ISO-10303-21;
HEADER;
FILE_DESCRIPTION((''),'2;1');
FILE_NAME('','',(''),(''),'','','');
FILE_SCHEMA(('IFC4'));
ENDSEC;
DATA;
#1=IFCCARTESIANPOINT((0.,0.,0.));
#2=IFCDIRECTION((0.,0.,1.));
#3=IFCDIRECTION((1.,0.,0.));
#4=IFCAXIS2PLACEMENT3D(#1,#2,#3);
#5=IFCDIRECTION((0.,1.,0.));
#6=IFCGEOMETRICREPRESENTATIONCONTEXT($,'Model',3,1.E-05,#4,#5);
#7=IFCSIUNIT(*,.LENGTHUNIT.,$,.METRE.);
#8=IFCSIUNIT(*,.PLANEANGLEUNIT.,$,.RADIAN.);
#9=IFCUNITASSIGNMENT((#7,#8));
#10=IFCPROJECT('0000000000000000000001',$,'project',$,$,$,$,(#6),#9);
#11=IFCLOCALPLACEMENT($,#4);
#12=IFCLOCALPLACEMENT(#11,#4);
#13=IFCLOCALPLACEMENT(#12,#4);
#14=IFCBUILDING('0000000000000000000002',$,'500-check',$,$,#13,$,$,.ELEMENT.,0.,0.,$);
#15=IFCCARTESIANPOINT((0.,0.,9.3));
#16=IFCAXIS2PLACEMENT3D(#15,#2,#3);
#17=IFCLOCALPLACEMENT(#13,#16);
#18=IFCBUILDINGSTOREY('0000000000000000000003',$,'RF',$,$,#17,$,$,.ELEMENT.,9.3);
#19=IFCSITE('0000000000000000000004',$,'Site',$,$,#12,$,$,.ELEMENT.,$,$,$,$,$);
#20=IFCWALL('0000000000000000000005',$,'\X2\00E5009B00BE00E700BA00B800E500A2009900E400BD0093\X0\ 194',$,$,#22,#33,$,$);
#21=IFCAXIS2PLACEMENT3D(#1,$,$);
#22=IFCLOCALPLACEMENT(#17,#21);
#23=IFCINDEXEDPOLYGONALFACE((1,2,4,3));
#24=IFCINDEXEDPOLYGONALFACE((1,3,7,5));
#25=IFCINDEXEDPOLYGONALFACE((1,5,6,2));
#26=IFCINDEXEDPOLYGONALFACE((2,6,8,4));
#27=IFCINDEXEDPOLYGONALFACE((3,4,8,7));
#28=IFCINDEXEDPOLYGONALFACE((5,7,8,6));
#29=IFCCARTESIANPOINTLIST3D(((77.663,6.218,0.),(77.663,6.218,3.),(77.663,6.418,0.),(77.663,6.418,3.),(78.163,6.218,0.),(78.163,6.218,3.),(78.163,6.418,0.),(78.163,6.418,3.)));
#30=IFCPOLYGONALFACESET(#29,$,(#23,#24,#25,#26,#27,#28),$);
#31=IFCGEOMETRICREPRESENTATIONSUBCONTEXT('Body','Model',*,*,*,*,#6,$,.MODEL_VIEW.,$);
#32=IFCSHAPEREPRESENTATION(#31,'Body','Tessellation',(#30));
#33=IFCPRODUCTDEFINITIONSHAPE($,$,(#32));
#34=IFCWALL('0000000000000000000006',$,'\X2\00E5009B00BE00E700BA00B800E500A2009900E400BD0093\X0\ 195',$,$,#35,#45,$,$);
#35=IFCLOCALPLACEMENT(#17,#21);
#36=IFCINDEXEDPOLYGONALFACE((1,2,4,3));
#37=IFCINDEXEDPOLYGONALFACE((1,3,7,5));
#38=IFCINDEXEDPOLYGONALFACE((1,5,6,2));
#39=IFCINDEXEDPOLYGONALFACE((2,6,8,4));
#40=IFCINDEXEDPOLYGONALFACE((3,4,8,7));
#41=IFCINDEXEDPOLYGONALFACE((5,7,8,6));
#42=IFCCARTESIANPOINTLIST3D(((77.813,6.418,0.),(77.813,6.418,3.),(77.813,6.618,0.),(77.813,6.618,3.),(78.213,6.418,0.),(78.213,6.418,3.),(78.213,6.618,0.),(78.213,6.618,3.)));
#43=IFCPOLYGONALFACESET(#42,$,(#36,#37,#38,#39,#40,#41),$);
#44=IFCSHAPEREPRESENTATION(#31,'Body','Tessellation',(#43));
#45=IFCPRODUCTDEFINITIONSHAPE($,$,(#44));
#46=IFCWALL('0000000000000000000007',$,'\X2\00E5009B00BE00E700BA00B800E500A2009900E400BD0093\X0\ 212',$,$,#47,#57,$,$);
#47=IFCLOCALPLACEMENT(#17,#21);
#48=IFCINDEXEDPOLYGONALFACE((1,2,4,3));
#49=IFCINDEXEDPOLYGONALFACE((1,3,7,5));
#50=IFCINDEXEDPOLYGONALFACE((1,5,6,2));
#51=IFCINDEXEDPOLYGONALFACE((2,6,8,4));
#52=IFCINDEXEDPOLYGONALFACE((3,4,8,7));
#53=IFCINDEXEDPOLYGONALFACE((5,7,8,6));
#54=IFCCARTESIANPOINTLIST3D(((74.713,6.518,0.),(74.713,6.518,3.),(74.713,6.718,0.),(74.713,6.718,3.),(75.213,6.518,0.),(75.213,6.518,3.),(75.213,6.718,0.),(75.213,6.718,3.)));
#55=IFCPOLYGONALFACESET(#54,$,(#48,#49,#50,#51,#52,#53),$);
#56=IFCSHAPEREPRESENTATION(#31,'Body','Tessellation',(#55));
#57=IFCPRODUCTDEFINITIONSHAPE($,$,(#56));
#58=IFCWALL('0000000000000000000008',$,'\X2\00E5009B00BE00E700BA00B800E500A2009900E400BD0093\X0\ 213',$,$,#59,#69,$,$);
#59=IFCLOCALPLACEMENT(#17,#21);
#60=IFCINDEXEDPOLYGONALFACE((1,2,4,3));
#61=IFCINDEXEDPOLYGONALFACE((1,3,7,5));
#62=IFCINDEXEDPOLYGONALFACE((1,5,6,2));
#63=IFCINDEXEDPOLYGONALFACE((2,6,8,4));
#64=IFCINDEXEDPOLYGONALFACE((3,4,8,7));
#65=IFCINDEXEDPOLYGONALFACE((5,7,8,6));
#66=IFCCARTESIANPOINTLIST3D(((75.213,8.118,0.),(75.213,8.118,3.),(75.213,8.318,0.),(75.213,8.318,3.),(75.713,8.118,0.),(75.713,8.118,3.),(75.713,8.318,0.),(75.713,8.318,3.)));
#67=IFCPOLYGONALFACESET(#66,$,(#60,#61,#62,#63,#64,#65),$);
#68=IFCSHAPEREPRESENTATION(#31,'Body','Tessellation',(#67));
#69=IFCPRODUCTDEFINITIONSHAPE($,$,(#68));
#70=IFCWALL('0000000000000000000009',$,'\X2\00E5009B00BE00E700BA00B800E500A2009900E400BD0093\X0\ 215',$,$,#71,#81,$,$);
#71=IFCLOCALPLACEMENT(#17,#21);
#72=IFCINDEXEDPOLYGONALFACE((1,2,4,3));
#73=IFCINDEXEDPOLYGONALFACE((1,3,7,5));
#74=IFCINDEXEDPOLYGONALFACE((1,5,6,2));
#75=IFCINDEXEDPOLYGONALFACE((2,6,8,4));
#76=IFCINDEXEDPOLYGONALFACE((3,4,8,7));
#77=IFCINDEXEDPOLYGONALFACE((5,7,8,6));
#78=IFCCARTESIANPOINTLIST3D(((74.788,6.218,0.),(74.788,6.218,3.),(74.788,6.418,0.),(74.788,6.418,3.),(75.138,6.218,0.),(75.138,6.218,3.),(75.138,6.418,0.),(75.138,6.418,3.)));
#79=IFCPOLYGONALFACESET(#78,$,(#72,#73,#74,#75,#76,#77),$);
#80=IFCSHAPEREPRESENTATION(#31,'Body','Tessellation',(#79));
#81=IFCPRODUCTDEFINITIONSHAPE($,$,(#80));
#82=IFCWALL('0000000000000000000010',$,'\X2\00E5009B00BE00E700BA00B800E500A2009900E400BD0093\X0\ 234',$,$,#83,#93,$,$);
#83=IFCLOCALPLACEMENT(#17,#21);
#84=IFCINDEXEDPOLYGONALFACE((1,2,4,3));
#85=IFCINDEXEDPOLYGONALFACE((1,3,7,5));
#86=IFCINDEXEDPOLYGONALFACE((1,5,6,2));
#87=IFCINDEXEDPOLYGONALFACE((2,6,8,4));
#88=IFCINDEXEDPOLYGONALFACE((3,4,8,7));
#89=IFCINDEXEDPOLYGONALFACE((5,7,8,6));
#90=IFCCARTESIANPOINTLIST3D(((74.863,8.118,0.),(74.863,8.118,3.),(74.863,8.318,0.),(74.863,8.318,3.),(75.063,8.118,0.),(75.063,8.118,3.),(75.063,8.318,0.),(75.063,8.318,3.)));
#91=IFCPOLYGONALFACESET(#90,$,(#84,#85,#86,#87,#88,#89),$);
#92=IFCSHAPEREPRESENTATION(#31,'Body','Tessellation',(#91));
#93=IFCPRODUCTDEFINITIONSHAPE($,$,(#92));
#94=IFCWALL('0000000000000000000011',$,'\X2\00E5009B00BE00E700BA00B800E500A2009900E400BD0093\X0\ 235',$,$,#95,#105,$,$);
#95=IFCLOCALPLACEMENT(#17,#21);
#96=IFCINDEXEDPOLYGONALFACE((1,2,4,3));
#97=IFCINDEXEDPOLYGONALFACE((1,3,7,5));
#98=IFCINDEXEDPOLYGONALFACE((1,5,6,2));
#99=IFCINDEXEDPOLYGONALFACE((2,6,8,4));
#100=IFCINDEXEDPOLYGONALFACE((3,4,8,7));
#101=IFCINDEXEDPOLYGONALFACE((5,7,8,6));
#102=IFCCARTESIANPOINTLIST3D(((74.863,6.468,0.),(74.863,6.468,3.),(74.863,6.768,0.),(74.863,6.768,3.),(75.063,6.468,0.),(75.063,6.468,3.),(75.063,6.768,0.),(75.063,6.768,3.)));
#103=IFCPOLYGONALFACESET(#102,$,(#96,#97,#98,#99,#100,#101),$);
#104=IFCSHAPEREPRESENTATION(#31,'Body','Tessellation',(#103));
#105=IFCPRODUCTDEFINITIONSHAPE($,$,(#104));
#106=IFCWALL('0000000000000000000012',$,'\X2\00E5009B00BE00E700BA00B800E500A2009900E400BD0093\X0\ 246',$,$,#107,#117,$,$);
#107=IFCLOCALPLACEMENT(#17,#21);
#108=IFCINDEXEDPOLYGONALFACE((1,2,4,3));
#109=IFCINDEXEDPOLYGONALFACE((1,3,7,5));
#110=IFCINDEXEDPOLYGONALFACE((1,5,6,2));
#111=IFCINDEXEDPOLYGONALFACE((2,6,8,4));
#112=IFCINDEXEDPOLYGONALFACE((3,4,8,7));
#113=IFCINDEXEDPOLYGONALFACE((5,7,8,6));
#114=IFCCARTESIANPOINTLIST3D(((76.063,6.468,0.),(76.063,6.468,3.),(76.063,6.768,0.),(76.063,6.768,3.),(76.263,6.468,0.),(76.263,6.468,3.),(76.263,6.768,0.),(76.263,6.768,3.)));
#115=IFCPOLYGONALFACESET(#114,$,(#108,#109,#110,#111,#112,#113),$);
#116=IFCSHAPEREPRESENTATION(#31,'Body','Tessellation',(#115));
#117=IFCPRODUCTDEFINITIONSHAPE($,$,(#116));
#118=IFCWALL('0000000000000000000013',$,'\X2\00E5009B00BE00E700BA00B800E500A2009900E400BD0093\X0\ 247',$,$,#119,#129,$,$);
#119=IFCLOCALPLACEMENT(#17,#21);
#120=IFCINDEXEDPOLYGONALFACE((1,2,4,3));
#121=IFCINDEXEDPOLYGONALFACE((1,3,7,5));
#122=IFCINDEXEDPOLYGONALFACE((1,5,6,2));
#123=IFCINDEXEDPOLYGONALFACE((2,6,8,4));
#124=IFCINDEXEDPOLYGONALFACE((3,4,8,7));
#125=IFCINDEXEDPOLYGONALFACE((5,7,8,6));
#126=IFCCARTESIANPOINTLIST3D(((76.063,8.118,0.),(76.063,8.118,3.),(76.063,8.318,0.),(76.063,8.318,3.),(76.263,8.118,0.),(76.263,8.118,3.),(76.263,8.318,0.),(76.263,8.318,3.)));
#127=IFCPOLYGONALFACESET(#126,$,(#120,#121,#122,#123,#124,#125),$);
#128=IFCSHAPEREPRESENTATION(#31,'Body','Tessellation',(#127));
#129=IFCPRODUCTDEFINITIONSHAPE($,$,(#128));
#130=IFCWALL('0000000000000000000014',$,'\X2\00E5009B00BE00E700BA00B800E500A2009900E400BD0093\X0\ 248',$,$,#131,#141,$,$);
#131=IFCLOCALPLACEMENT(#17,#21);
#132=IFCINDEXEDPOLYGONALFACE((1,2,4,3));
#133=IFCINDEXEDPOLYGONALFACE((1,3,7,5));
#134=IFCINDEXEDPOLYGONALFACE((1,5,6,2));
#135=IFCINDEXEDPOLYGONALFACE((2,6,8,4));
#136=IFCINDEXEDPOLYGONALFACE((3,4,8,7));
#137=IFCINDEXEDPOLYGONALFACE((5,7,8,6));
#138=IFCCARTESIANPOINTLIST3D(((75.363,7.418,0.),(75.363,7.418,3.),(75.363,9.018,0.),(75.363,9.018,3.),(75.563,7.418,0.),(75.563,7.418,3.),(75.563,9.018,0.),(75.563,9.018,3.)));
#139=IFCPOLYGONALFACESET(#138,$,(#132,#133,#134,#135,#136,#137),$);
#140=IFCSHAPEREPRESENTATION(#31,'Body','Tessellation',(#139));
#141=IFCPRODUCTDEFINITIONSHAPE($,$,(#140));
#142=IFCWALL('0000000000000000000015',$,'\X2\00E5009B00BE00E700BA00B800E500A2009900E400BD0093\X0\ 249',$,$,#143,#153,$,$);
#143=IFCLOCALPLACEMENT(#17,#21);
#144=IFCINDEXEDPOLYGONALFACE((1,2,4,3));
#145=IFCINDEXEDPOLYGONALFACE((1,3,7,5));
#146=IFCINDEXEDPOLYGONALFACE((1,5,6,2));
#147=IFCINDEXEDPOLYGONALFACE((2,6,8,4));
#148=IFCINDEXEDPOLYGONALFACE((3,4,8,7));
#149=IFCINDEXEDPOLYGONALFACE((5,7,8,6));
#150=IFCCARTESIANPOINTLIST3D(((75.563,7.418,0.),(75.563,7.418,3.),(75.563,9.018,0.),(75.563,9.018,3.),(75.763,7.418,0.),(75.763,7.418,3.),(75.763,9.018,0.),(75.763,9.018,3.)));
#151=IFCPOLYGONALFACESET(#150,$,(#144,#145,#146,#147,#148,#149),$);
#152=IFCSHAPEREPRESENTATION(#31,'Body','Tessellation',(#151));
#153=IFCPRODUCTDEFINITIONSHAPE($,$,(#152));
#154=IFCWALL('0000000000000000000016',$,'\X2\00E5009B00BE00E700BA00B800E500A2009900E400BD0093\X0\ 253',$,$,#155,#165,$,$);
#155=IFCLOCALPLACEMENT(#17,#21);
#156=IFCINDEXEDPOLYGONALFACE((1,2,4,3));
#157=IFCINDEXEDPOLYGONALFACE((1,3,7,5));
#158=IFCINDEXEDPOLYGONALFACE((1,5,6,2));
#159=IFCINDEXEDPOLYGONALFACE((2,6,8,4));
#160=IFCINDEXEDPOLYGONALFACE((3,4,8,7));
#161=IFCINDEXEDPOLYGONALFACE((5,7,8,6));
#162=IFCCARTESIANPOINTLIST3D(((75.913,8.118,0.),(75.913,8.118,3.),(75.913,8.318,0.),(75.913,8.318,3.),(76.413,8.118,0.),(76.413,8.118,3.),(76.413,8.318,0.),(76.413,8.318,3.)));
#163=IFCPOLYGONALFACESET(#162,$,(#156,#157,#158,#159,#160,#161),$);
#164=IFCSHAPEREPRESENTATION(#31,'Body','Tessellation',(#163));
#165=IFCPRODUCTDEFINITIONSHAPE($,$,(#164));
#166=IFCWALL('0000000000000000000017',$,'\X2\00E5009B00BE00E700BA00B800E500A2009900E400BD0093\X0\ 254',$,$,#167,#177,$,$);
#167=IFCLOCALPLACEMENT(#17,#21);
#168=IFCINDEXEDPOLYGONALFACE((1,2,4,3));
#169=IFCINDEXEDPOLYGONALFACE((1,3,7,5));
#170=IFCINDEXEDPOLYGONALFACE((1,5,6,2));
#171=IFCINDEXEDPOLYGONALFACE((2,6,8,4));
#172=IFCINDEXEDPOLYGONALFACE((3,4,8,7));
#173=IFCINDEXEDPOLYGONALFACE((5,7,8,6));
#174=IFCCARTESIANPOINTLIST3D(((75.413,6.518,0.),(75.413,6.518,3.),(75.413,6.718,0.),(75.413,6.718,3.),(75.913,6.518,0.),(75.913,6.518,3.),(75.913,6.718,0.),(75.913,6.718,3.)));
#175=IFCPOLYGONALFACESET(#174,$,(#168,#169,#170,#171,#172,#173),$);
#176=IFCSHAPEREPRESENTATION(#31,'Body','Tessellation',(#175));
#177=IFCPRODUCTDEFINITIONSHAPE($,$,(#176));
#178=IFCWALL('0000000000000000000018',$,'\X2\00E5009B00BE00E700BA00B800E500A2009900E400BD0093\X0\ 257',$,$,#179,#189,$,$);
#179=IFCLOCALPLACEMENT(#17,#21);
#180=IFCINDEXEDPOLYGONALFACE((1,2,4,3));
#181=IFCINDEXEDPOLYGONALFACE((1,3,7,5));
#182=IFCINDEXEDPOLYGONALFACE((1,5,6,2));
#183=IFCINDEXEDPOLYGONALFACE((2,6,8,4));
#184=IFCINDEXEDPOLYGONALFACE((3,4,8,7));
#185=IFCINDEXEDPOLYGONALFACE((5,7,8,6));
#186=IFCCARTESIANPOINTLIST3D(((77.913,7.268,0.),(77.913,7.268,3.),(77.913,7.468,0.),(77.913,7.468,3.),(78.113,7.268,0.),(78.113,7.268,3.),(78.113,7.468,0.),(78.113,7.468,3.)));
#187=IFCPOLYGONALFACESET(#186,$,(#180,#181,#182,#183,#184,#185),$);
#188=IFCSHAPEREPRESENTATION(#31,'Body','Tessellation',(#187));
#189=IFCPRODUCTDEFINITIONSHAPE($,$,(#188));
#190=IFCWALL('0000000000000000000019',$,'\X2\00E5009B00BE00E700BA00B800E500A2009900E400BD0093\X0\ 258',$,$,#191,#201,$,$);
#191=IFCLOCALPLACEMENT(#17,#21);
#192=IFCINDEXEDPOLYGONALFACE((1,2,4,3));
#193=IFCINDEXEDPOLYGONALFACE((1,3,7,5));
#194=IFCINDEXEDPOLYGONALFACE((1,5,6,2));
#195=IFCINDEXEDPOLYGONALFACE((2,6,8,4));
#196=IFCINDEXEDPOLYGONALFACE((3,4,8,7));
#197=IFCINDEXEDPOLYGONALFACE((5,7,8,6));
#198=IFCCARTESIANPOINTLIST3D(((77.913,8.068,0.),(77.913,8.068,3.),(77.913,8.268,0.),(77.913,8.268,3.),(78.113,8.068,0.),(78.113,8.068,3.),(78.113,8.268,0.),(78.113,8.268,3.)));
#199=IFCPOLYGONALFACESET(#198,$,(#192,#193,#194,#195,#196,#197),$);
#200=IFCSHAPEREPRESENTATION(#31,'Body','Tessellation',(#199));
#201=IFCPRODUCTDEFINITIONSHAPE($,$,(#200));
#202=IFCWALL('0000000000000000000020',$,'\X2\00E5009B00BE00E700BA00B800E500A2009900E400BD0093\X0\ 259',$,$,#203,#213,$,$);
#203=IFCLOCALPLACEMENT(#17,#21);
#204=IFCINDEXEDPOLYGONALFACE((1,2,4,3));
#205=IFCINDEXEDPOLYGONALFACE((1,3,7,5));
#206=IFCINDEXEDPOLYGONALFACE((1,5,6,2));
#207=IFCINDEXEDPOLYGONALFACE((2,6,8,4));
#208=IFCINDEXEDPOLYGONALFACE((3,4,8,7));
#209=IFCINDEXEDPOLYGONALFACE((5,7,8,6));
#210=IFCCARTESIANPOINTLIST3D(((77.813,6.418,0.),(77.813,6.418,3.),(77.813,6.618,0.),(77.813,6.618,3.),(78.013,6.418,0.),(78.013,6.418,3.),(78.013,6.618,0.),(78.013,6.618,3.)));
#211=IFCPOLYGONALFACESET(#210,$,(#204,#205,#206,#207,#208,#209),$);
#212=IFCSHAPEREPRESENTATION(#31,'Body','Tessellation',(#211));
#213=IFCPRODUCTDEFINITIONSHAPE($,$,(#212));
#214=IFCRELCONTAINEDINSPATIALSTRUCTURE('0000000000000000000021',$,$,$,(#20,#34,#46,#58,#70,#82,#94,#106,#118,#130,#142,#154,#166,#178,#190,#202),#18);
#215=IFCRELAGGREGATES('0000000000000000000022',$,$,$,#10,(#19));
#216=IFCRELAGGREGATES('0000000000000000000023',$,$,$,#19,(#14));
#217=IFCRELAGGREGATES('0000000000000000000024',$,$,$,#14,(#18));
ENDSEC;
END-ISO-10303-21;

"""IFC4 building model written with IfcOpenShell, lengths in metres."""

from ifc_helpers import new_model, si_unit, direction, frame, frame_2d, origin_with_axes, place, context, subcontext, project, spatial, rectangle, extrude, element, save


model = new_model("IFC4")

# Units and contexts
model_context = context("Model", 3, precision=1e-05, world=origin_with_axes(), true_north=direction((0.0, 1.0, 0.0)))
body_context = subcontext(model_context, "Body", "Model", "MODEL_VIEW")
ifc_project = project(units=[si_unit("LENGTHUNIT", "METRE"), si_unit("PLANEANGLEUNIT", "RADIAN")], contexts=[model_context])

# Site, building, storey
placement = place(None, origin_with_axes())
site_placement = place(placement, origin_with_axes())
site = spatial("IfcSite", under=ifc_project, at=site_placement, Name="Site", CompositionType="ELEMENT")
building_placement = place(site_placement, origin_with_axes())
building = spatial("IfcBuilding", under=site, at=building_placement, Name="500-check", CompositionType="ELEMENT", ElevationOfRefHeight=0.0, ElevationOfTerrain=0.0)
storey_placement = place(building_placement, frame((0.0, 0.0, 9.3), z_axis=(0.0, 0.0, 1.0), x_axis=(1.0, 0.0, 0.0)))
storey = spatial("IfcBuildingStorey", under=building, at=storey_placement, Name="RF", CompositionType="ELEMENT", Elevation=9.3)

# Walls
wall_1_placement = place(storey_placement, frame((77.913, 6.318, 0.0), z_axis=(0.0, 0.0, 1.0), x_axis=(1.0, 0.0, 0.0)))
element("IfcWall", 1, at=wall_1_placement, inside=storey, Name="å\u009b¾çº¸å¢\u0099ä½\u0093 194", context=body_context, shape_type="SweptSolid", body=[
    extrude(rectangle(XDim=0.5, YDim=0.2, at=frame_2d((0.0, 0.0), x_axis=(1.0, 0.0, 0.0))), frame((0.0, 0.0, 0.0), z_axis=(0.0, 0.0, 1.0)), (0.0, 0.0, 1.0), 3.0),
])
wall_2_placement = place(storey_placement, frame((78.013, 6.518, 0.0), z_axis=(0.0, 0.0, 1.0), x_axis=(1.0, 0.0, 0.0)))
element("IfcWall", 2, at=wall_2_placement, inside=storey, Name="å\u009b¾çº¸å¢\u0099ä½\u0093 195", context=body_context, shape_type="SweptSolid", body=[
    extrude(rectangle(XDim=0.4, YDim=0.2, at=frame_2d((0.0, 0.0), x_axis=(1.0, 0.0, 0.0))), frame((0.0, 0.0, 0.0), z_axis=(0.0, 0.0, 1.0)), (0.0, 0.0, 1.0), 3.0),
])
for number, where, z_axis, x_axis, name in (
    (3, (74.963, 6.618, 0.0), (0.0, 0.0, 1.0), (1.0, 0.0, 0.0), "å\u009b¾çº¸å¢\u0099ä½\u0093 212"),
    (4, (75.463, 8.218, 0.0), (0.0, 0.0, 1.0), (-1.0, 0.0, 0.0), "å\u009b¾çº¸å¢\u0099ä½\u0093 213"),
):
    element("IfcWall", number, at=place(storey_placement, frame(where, z_axis=z_axis, x_axis=x_axis)), inside=storey, Name=name, context=body_context, shape_type="SweptSolid", body=[
        extrude(rectangle(XDim=0.5, YDim=0.2, at=frame_2d((0.0, 0.0), x_axis=(1.0, 0.0, 0.0))), frame((0.0, 0.0, 0.0), z_axis=(0.0, 0.0, 1.0)), (0.0, 0.0, 1.0), 3.0),
    ])
wall_3_placement = place(storey_placement, frame((74.963, 6.318, 0.0), z_axis=(0.0, 0.0, 1.0), x_axis=(1.0, 0.0, 0.0)))
element("IfcWall", 5, at=wall_3_placement, inside=storey, Name="å\u009b¾çº¸å¢\u0099ä½\u0093 215", context=body_context, shape_type="SweptSolid", body=[
    extrude(rectangle(XDim=0.35, YDim=0.2, at=frame_2d((0.0, 0.0), x_axis=(1.0, 0.0, 0.0))), frame((0.0, 0.0, 0.0), z_axis=(0.0, 0.0, 1.0)), (0.0, 0.0, 1.0), 3.0),
])
wall_4_placement = place(storey_placement, frame((74.963, 8.218, 0.0), z_axis=(0.0, 0.0, 1.0), x_axis=(0.0, 1.0, 0.0)))
element("IfcWall", 6, at=wall_4_placement, inside=storey, Name="å\u009b¾çº¸å¢\u0099ä½\u0093 234", context=body_context, shape_type="SweptSolid", body=[
    extrude(rectangle(XDim=0.2, YDim=0.2, at=frame_2d((0.0, 0.0), x_axis=(1.0, 0.0, 0.0))), frame((0.0, 0.0, 0.0), z_axis=(0.0, 0.0, 1.0)), (0.0, 0.0, 1.0), 3.0),
])
for number, where, z_axis, x_axis, name in (
    (7, (74.963, 6.618, 0.0), (0.0, 0.0, 1.0), (0.0, -1.0, 0.0), "å\u009b¾çº¸å¢\u0099ä½\u0093 235"),
    (8, (76.163, 6.618, 0.0), (0.0, 0.0, 1.0), (0.0, -1.0, 0.0), "å\u009b¾çº¸å¢\u0099ä½\u0093 246"),
):
    element("IfcWall", number, at=place(storey_placement, frame(where, z_axis=z_axis, x_axis=x_axis)), inside=storey, Name=name, context=body_context, shape_type="SweptSolid", body=[
        extrude(rectangle(XDim=0.3, YDim=0.2, at=frame_2d((0.0, 0.0), x_axis=(1.0, 0.0, 0.0))), frame((0.0, 0.0, 0.0), z_axis=(0.0, 0.0, 1.0)), (0.0, 0.0, 1.0), 3.0),
    ])
wall_5_placement = place(storey_placement, frame((76.163, 8.218, 0.0), z_axis=(0.0, 0.0, 1.0), x_axis=(0.0, 1.0, 0.0)))
element("IfcWall", 9, at=wall_5_placement, inside=storey, Name="å\u009b¾çº¸å¢\u0099ä½\u0093 247", context=body_context, shape_type="SweptSolid", body=[
    extrude(rectangle(XDim=0.2, YDim=0.2, at=frame_2d((0.0, 0.0), x_axis=(1.0, 0.0, 0.0))), frame((0.0, 0.0, 0.0), z_axis=(0.0, 0.0, 1.0)), (0.0, 0.0, 1.0), 3.0),
])
for number, where, z_axis, x_axis, name in (
    (10, (75.463, 8.218, 0.0), (0.0, 0.0, 1.0), (0.0, -1.0, 0.0), "å\u009b¾çº¸å¢\u0099ä½\u0093 248"),
    (11, (75.663, 8.218, 0.0), (0.0, 0.0, 1.0), (0.0, -1.0, 0.0), "å\u009b¾çº¸å¢\u0099ä½\u0093 249"),
):
    element("IfcWall", number, at=place(storey_placement, frame(where, z_axis=z_axis, x_axis=x_axis)), inside=storey, Name=name, context=body_context, shape_type="SweptSolid", body=[
        extrude(rectangle(XDim=1.6, YDim=0.2, at=frame_2d((0.0, 0.0), x_axis=(1.0, 0.0, 0.0))), frame((0.0, 0.0, 0.0), z_axis=(0.0, 0.0, 1.0)), (0.0, 0.0, 1.0), 3.0),
    ])
for number, where, z_axis, x_axis, name in (
    (12, (76.163, 8.218, 0.0), (0.0, 0.0, 1.0), (-1.0, 0.0, 0.0), "å\u009b¾çº¸å¢\u0099ä½\u0093 253"),
    (13, (75.663, 6.618, 0.0), (0.0, 0.0, 1.0), (1.0, 0.0, 0.0), "å\u009b¾çº¸å¢\u0099ä½\u0093 254"),
):
    element("IfcWall", number, at=place(storey_placement, frame(where, z_axis=z_axis, x_axis=x_axis)), inside=storey, Name=name, context=body_context, shape_type="SweptSolid", body=[
        extrude(rectangle(XDim=0.5, YDim=0.2, at=frame_2d((0.0, 0.0), x_axis=(1.0, 0.0, 0.0))), frame((0.0, 0.0, 0.0), z_axis=(0.0, 0.0, 1.0)), (0.0, 0.0, 1.0), 3.0),
    ])
for number, where, z_axis, x_axis, name in (
    (14, (78.013, 7.368, 0.0), (0.0, 0.0, 1.0), (-1.0, 0.0, 0.0), "å\u009b¾çº¸å¢\u0099ä½\u0093 257"),
    (15, (78.013, 8.168, 0.0), (0.0, 0.0, 1.0), (-1.0, 0.0, 0.0), "å\u009b¾çº¸å¢\u0099ä½\u0093 258"),
    (16, (77.913, 6.518, 0.0), (0.0, 0.0, 1.0), (0.0, -1.0, 0.0), "å\u009b¾çº¸å¢\u0099ä½\u0093 259"),
):
    element("IfcWall", number, at=place(storey_placement, frame(where, z_axis=z_axis, x_axis=x_axis)), inside=storey, Name=name, context=body_context, shape_type="SweptSolid", body=[
        extrude(rectangle(XDim=0.2, YDim=0.2, at=frame_2d((0.0, 0.0), x_axis=(1.0, 0.0, 0.0))), frame((0.0, 0.0, 0.0), z_axis=(0.0, 0.0, 1.0)), (0.0, 0.0, 1.0), 3.0),
    ])

save(model, "model.ifc")
